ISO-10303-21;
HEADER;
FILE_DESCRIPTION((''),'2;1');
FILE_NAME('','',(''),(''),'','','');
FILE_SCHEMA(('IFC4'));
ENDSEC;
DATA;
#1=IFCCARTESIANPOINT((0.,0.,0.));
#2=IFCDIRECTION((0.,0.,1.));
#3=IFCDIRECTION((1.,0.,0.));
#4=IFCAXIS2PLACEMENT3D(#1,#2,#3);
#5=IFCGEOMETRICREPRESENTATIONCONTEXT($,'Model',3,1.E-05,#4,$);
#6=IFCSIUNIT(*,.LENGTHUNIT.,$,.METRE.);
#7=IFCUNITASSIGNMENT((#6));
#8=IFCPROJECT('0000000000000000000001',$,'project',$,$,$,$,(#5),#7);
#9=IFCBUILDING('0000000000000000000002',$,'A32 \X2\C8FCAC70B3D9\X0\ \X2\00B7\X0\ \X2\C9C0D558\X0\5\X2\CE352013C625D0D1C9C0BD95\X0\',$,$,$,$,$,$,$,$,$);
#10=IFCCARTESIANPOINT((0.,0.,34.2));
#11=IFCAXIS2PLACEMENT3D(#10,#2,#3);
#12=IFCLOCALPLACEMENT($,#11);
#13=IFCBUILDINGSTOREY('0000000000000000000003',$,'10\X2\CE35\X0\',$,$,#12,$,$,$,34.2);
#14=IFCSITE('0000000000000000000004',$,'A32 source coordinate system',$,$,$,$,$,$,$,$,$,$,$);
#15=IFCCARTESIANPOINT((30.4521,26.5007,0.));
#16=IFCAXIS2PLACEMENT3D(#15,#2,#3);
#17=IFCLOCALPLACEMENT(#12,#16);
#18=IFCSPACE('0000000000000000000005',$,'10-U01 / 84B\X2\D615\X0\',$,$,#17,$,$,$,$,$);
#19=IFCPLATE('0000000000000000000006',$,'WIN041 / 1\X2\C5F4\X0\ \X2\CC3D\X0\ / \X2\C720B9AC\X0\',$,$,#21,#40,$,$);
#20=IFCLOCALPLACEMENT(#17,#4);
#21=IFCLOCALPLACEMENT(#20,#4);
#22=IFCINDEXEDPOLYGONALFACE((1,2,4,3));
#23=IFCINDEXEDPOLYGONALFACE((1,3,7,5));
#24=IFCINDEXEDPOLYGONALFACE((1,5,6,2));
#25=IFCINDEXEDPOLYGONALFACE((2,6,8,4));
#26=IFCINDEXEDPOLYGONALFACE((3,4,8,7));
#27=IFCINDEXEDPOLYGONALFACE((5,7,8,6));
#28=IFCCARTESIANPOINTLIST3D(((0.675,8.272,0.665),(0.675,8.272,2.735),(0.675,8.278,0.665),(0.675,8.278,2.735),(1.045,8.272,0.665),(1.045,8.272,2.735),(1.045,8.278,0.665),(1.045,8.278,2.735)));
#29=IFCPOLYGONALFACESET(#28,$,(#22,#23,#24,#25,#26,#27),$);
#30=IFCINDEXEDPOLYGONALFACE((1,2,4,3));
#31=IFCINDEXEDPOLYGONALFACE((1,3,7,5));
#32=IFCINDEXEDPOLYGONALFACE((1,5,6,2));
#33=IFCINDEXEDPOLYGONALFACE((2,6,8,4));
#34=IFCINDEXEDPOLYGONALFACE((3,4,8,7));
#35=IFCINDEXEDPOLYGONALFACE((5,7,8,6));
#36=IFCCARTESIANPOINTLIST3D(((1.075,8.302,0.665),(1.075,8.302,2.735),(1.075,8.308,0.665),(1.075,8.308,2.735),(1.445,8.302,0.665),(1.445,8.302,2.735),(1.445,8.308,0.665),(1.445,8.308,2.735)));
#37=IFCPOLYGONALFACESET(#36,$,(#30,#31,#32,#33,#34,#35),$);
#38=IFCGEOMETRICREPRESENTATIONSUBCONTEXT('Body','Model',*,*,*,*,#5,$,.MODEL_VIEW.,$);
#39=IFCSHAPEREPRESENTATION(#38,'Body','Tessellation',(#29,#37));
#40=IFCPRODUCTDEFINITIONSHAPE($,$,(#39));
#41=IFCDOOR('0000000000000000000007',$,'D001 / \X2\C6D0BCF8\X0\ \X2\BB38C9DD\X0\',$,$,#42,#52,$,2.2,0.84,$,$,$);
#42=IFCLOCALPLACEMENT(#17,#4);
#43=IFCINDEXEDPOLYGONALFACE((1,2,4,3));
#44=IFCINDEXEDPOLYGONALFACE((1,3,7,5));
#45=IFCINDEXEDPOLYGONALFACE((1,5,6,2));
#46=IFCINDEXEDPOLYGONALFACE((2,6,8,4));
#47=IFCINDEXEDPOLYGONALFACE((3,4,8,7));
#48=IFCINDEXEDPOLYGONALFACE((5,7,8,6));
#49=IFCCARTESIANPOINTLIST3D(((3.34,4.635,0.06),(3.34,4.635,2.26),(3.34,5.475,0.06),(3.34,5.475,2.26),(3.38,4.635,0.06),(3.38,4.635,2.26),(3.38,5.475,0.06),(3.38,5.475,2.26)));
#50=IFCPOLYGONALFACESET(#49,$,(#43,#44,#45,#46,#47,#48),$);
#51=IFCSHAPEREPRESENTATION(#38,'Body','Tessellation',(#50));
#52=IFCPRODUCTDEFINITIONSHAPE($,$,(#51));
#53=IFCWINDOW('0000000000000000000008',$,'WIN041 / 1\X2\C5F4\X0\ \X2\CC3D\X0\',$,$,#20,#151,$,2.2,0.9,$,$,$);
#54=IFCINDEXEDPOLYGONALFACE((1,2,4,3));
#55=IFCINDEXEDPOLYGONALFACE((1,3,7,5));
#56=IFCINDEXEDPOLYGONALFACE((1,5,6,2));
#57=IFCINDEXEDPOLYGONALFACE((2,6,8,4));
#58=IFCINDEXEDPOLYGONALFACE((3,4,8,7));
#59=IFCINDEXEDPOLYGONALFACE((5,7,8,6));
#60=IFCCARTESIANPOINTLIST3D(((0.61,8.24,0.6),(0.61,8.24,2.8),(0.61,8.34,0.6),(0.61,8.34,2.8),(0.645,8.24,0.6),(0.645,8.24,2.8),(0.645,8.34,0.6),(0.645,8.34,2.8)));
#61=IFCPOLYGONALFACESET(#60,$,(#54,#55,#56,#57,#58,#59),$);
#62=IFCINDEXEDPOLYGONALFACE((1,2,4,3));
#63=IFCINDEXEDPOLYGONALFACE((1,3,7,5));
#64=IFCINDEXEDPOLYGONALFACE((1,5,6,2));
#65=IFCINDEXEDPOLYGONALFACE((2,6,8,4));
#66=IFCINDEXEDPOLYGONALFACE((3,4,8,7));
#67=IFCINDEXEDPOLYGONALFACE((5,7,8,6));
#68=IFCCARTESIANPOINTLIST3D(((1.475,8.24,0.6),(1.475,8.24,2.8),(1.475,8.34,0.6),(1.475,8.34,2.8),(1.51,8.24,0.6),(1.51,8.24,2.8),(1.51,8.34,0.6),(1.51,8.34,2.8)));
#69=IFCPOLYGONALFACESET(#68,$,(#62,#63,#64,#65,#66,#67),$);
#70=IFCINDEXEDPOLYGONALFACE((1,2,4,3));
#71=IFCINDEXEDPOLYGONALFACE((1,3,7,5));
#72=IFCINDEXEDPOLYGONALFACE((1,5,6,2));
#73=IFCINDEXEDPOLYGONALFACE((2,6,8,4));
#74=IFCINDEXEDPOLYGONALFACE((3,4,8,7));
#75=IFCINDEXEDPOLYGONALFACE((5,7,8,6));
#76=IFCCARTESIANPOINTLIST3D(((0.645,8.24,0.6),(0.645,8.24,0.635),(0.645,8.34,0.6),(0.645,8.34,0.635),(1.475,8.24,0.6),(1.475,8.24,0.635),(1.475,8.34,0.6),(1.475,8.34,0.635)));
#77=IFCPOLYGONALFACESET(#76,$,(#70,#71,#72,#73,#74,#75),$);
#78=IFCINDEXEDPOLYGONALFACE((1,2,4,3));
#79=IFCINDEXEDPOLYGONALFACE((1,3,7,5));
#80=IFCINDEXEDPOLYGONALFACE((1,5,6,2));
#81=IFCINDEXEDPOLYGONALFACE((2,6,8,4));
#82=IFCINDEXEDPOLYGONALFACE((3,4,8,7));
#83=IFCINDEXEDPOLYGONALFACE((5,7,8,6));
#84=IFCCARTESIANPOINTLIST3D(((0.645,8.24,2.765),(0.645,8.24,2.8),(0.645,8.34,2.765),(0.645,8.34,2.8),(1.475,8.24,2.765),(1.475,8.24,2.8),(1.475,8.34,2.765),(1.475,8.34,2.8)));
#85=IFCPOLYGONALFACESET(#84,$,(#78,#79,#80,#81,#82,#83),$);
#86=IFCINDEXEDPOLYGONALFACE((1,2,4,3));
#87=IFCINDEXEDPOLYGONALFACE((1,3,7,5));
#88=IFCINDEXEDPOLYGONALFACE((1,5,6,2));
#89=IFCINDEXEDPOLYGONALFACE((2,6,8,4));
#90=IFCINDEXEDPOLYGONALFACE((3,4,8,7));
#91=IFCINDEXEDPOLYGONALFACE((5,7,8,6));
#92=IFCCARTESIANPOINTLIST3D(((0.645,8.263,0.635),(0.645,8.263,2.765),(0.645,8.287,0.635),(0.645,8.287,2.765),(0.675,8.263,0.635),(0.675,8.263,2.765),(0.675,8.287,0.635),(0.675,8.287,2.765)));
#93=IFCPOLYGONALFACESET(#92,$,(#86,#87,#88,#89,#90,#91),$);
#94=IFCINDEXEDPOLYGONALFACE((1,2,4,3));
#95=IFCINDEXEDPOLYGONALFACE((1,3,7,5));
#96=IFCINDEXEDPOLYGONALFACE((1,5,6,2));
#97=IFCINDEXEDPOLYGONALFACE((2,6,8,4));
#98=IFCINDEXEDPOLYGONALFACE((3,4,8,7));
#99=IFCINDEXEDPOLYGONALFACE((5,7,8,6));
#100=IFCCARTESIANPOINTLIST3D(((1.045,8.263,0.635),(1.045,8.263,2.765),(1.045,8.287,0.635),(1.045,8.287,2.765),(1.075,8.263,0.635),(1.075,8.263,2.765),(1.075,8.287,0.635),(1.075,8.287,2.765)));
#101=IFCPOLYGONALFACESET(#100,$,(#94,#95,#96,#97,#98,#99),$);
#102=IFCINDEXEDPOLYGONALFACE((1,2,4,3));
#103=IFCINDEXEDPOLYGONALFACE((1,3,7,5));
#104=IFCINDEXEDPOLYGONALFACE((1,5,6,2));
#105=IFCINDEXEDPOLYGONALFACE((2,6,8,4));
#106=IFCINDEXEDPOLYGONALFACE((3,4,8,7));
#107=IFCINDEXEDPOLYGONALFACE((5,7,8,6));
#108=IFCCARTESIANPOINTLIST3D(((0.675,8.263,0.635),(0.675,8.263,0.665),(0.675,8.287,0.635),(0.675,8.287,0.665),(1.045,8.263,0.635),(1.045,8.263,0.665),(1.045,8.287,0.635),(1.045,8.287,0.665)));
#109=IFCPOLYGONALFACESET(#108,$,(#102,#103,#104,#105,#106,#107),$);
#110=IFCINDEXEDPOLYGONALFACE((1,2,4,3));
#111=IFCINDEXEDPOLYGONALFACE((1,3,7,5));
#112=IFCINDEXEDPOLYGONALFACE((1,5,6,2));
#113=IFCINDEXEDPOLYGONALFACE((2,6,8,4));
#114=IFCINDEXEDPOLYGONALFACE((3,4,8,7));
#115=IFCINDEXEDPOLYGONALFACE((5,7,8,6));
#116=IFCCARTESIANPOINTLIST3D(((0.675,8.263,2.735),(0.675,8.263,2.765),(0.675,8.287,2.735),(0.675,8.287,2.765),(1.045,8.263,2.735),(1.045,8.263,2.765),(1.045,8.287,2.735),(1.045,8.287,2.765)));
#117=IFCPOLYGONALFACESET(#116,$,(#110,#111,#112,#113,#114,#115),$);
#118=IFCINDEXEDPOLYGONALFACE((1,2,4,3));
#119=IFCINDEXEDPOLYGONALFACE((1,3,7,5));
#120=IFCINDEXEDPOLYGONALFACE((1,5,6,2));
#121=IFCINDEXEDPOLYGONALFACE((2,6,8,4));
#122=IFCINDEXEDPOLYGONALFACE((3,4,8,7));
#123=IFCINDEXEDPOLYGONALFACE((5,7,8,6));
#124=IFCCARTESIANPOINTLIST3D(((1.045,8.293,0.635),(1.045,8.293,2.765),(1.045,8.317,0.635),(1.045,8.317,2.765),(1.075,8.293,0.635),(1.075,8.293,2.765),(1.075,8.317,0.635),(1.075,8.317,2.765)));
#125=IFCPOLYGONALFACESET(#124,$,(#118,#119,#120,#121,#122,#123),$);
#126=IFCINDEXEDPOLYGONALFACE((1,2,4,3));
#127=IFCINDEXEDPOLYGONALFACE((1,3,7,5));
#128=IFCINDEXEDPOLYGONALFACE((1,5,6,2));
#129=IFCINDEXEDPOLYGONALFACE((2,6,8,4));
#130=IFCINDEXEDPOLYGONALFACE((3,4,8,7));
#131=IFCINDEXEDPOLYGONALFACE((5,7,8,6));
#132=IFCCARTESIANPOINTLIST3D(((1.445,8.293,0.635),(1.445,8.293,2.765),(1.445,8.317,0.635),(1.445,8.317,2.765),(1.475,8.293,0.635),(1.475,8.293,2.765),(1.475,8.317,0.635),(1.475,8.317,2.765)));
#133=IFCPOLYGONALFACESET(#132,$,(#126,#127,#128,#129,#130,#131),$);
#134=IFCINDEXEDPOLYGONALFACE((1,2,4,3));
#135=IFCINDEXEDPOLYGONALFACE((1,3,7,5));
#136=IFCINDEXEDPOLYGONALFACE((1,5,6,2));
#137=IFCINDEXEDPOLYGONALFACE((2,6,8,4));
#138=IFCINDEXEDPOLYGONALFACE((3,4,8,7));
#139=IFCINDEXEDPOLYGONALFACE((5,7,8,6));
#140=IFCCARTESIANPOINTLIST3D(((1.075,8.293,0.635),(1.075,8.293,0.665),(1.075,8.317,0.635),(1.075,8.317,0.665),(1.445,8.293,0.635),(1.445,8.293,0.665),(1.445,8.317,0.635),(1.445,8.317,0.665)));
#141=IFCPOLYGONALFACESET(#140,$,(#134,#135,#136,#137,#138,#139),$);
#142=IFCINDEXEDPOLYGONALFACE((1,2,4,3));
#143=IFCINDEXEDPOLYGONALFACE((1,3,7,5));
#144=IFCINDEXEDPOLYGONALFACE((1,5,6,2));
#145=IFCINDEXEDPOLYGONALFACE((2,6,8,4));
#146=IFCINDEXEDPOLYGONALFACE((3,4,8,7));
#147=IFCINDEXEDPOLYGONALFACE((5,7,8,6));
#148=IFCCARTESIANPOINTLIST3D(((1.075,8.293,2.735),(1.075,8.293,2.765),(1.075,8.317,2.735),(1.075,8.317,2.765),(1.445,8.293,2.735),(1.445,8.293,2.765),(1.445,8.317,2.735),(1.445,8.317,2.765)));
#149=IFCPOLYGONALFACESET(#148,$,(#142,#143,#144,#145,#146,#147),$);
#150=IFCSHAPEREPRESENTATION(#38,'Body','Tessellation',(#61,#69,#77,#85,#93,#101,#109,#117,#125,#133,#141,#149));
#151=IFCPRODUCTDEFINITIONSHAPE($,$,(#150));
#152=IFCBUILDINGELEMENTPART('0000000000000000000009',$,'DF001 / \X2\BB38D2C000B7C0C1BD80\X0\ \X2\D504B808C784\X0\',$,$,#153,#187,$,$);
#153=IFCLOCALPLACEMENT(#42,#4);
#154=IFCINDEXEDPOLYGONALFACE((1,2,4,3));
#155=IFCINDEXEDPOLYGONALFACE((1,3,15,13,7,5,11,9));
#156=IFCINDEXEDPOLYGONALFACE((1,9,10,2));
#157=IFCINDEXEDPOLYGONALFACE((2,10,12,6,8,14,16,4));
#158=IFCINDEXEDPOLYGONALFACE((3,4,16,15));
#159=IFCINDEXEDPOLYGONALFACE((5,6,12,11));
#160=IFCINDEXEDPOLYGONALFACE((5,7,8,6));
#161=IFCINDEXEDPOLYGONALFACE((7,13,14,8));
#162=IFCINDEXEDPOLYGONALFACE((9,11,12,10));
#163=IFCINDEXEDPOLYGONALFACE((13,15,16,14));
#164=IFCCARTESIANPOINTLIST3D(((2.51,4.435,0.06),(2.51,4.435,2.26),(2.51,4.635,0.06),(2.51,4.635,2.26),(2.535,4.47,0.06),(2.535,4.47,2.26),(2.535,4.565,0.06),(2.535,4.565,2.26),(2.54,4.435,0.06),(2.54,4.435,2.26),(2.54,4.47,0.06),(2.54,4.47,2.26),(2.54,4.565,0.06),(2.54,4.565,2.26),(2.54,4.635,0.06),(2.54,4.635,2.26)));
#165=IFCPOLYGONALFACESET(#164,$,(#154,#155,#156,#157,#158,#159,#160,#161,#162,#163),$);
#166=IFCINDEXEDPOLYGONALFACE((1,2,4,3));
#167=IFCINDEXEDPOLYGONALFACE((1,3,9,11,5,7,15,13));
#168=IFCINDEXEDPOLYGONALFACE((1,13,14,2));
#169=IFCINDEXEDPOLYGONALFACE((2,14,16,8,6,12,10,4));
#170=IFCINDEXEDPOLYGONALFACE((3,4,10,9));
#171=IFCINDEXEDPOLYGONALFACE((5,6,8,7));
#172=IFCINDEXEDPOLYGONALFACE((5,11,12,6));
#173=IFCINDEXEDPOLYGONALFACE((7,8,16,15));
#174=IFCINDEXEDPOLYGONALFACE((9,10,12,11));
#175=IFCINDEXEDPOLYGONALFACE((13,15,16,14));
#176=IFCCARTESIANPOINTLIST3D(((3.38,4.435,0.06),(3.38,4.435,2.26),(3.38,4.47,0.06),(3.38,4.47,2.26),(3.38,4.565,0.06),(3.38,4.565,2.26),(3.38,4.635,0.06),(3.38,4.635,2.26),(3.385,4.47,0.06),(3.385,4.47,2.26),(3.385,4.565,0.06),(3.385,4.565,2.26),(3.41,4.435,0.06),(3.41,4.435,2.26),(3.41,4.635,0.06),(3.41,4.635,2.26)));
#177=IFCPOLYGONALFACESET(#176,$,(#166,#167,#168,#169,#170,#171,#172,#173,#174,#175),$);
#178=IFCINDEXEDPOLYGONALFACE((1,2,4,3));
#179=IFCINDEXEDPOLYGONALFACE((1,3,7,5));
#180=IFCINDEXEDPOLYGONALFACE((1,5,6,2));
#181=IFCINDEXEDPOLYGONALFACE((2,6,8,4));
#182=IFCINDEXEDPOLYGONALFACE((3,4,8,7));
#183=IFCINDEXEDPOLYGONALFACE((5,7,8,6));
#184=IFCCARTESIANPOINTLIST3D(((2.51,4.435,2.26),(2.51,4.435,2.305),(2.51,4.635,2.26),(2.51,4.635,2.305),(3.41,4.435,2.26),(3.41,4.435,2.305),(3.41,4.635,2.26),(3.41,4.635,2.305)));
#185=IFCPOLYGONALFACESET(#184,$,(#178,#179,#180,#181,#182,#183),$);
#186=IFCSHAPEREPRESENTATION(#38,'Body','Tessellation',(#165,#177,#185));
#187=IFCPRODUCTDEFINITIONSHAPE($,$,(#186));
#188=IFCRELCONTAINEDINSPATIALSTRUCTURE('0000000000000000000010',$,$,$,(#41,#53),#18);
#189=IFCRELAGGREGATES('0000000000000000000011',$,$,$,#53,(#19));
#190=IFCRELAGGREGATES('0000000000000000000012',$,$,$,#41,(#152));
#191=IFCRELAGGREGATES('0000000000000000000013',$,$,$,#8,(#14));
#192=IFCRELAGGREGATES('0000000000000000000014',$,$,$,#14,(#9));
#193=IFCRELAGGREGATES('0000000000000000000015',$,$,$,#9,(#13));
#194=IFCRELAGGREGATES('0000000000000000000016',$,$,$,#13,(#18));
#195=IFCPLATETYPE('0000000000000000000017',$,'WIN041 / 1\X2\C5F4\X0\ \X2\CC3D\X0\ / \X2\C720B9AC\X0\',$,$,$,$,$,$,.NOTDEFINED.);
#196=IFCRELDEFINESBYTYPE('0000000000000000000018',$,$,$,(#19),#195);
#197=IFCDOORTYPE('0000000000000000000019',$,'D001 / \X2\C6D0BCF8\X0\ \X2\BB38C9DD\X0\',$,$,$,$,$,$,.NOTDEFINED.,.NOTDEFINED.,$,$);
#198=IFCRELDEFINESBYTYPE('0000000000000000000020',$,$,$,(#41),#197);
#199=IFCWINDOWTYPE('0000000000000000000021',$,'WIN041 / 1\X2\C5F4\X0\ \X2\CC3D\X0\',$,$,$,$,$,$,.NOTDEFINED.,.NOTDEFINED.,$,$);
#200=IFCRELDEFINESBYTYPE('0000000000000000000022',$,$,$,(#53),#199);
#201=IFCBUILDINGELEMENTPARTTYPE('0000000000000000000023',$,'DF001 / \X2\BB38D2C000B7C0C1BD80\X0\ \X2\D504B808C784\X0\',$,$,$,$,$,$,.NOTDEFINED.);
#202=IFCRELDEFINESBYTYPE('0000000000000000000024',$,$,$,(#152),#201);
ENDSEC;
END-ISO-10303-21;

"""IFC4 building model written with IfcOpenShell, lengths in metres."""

from ifc_helpers import new_model, si_unit, frame, origin, origin_with_axes, place, context, subcontext, project, spatial, polyline, outline, extrude, source, transform, mapped, type_object, type_shapes, element, aggregate, save


model = new_model("IFC4")

# Units and contexts
model_context = context("Model", 3, precision=1e-05, world=origin_with_axes())
body_context = subcontext(model_context, "Body", "Model", "MODEL_VIEW")
ifc_project = project(units=[si_unit("LENGTHUNIT", "METRE")], contexts=[model_context])

# Plate
storey_placement = place(None, frame((0.0, 0.0, 34.2), z_axis=(0.0, 0.0, 1.0), x_axis=(1.0, 0.0, 0.0)))
space_placement = place(storey_placement, frame((30.4521, 26.5007, 0.0), z_axis=(0.0, 0.0, 1.0), x_axis=(1.0, 0.0, 0.0)))
plate_type_1 = type_object("IfcPlateType", Name="WIN041 / 1열 창 / 유리", PredefinedType="NOTDEFINED")
shared_shape_1 = source(origin(), body_context, "Body", "SweptSolid", [
    extrude(outline(polyline([(0.675, 8.272), (0.675, 8.278), (1.045, 8.278), (1.045, 8.272), (0.675, 8.272)])), frame((0.0, 0.0, 0.665)), (0.0, 0.0, 1.0), 2.07),
    extrude(outline(polyline([(1.075, 8.302), (1.075, 8.308), (1.445, 8.308), (1.445, 8.302), (1.075, 8.302)])), frame((0.0, 0.0, 0.665)), (0.0, 0.0, 1.0), 2.07),
])
type_shapes(plate_type_1, [shared_shape_1])
window_1_placement = place(space_placement, origin_with_axes())
plate_1_placement = place(window_1_placement, origin_with_axes())
plate_1 = element("IfcPlate", 1, at=plate_1_placement, type_object=plate_type_1, Name="WIN041 / 1열 창 / 유리", context=body_context, shape_type="MappedRepresentation", body=[
    mapped(shared_shape_1, transform((0.0, 0.0, 0.0), scale=1.0)),
])

# Site, building, storey, space
site = spatial("IfcSite", under=ifc_project, Name="A32 source coordinate system")
building = spatial("IfcBuilding", under=site, Name="A32 주거동 · 지하5층–옥탑지붕")
storey = spatial("IfcBuildingStorey", under=building, at=storey_placement, Name="10층", Elevation=34.2)
space = spatial("IfcSpace", under=storey, at=space_placement, Name="10-U01 / 84B형")

# Door
door_type_1 = type_object("IfcDoorType", Name="D001 / 원본 문짝", OperationType="NOTDEFINED", PredefinedType="NOTDEFINED")
shared_shape_2 = source(origin(), body_context, "Body", "SweptSolid", [
    extrude(outline(polyline([(3.34, 5.475), (3.38, 5.475), (3.38, 4.635), (3.34, 4.635), (3.34, 5.475)])), frame((0.0, 0.0, 0.06)), (0.0, 0.0, 1.0), 2.2),
])
type_shapes(door_type_1, [shared_shape_2])
door_1_placement = place(space_placement, origin_with_axes())
door_1 = element("IfcDoor", 2, at=door_1_placement, inside=space, type_object=door_type_1, Name="D001 / 원본 문짝", OverallHeight=2.2, OverallWidth=0.84, context=body_context, shape_type="MappedRepresentation", body=[
    mapped(shared_shape_2, transform((0.0, 0.0, 0.0), scale=1.0)),
])

# Window
window_type_1 = type_object("IfcWindowType", Name="WIN041 / 1열 창", PartitioningType="NOTDEFINED", PredefinedType="NOTDEFINED")
shared_shape_3 = source(origin(), body_context, "Body", "SweptSolid", [
    extrude(outline(polyline([(0.61, 8.24), (0.61, 8.34), (0.645, 8.34), (0.645, 8.24), (0.61, 8.24)])), frame((0.0, 0.0, 0.6)), (0.0, 0.0, 1.0), 2.2),
    extrude(outline(polyline([(1.475, 8.24), (1.475, 8.34), (1.51, 8.34), (1.51, 8.24), (1.475, 8.24)])), frame((0.0, 0.0, 0.6)), (0.0, 0.0, 1.0), 2.2),
    extrude(outline(polyline([(0.645, 8.24), (0.645, 8.34), (1.475, 8.34), (1.475, 8.24), (0.645, 8.24)])), frame((0.0, 0.0, 0.6)), (0.0, 0.0, 1.0), 0.035),
    extrude(outline(polyline([(0.645, 8.24), (0.645, 8.34), (1.475, 8.34), (1.475, 8.24), (0.645, 8.24)])), frame((0.0, 0.0, 2.765)), (0.0, 0.0, 1.0), 0.035),
    extrude(outline(polyline([(0.645, 8.263), (0.645, 8.287), (0.675, 8.287), (0.675, 8.263), (0.645, 8.263)])), frame((0.0, 0.0, 0.635)), (0.0, 0.0, 1.0), 2.13),
    extrude(outline(polyline([(1.045, 8.263), (1.045, 8.287), (1.075, 8.287), (1.075, 8.263), (1.045, 8.263)])), frame((0.0, 0.0, 0.635)), (0.0, 0.0, 1.0), 2.13),
    extrude(outline(polyline([(0.675, 8.263), (0.675, 8.287), (1.045, 8.287), (1.045, 8.263), (0.675, 8.263)])), frame((0.0, 0.0, 0.635)), (0.0, 0.0, 1.0), 0.03),
    extrude(outline(polyline([(0.675, 8.263), (0.675, 8.287), (1.045, 8.287), (1.045, 8.263), (0.675, 8.263)])), frame((0.0, 0.0, 2.735)), (0.0, 0.0, 1.0), 0.03),
    extrude(outline(polyline([(1.045, 8.293), (1.045, 8.317), (1.075, 8.317), (1.075, 8.293), (1.045, 8.293)])), frame((0.0, 0.0, 0.635)), (0.0, 0.0, 1.0), 2.13),
    extrude(outline(polyline([(1.445, 8.293), (1.445, 8.317), (1.475, 8.317), (1.475, 8.293), (1.445, 8.293)])), frame((0.0, 0.0, 0.635)), (0.0, 0.0, 1.0), 2.13),
    extrude(outline(polyline([(1.075, 8.293), (1.075, 8.317), (1.445, 8.317), (1.445, 8.293), (1.075, 8.293)])), frame((0.0, 0.0, 0.635)), (0.0, 0.0, 1.0), 0.03),
    extrude(outline(polyline([(1.075, 8.293), (1.075, 8.317), (1.445, 8.317), (1.445, 8.293), (1.075, 8.293)])), frame((0.0, 0.0, 2.735)), (0.0, 0.0, 1.0), 0.03),
])
type_shapes(window_type_1, [shared_shape_3])
window_1 = element("IfcWindow", 3, at=window_1_placement, inside=space, type_object=window_type_1, Name="WIN041 / 1열 창", OverallHeight=2.2, OverallWidth=0.9, context=body_context, shape_type="MappedRepresentation", body=[
    mapped(shared_shape_3, transform((0.0, 0.0, 0.0), scale=1.0)),
])
aggregate(window_1, [plate_1])

# Building element part
building_element_part_type_1 = type_object("IfcBuildingElementPartType", Name="DF001 / 문틀·상부 프레임", PredefinedType="NOTDEFINED")
shared_shape_4 = source(origin(), body_context, "Body", "SweptSolid", [
    extrude(outline(polyline([(2.54, 4.635), (2.54, 4.565), (2.535, 4.565), (2.535, 4.47), (2.54, 4.47), (2.54, 4.435), (2.51, 4.435), (2.51, 4.635), (2.54, 4.635)])), frame((0.0, 0.0, 0.06)), (0.0, 0.0, 1.0), 2.2),
    extrude(outline(polyline([(3.41, 4.435), (3.38, 4.435), (3.38, 4.47), (3.385, 4.47), (3.385, 4.565), (3.38, 4.565), (3.38, 4.635), (3.41, 4.635), (3.41, 4.435)])), frame((0.0, 0.0, 0.06)), (0.0, 0.0, 1.0), 2.2),
    extrude(outline(polyline([(2.51, 4.435), (2.51, 4.635), (3.41, 4.635), (3.41, 4.435), (2.51, 4.435)])), frame((0.0, 0.0, 2.26)), (0.0, 0.0, 1.0), 0.045),
])
type_shapes(building_element_part_type_1, [shared_shape_4])
building_element_part_1_placement = place(door_1_placement, origin_with_axes())
building_element_part_1 = element("IfcBuildingElementPart", 4, at=building_element_part_1_placement, type_object=building_element_part_type_1, Name="DF001 / 문틀·상부 프레임", context=body_context, shape_type="MappedRepresentation", body=[
    mapped(shared_shape_4, transform((0.0, 0.0, 0.0), scale=1.0)),
])
aggregate(door_1, [building_element_part_1])

save(model, "model.ifc")
